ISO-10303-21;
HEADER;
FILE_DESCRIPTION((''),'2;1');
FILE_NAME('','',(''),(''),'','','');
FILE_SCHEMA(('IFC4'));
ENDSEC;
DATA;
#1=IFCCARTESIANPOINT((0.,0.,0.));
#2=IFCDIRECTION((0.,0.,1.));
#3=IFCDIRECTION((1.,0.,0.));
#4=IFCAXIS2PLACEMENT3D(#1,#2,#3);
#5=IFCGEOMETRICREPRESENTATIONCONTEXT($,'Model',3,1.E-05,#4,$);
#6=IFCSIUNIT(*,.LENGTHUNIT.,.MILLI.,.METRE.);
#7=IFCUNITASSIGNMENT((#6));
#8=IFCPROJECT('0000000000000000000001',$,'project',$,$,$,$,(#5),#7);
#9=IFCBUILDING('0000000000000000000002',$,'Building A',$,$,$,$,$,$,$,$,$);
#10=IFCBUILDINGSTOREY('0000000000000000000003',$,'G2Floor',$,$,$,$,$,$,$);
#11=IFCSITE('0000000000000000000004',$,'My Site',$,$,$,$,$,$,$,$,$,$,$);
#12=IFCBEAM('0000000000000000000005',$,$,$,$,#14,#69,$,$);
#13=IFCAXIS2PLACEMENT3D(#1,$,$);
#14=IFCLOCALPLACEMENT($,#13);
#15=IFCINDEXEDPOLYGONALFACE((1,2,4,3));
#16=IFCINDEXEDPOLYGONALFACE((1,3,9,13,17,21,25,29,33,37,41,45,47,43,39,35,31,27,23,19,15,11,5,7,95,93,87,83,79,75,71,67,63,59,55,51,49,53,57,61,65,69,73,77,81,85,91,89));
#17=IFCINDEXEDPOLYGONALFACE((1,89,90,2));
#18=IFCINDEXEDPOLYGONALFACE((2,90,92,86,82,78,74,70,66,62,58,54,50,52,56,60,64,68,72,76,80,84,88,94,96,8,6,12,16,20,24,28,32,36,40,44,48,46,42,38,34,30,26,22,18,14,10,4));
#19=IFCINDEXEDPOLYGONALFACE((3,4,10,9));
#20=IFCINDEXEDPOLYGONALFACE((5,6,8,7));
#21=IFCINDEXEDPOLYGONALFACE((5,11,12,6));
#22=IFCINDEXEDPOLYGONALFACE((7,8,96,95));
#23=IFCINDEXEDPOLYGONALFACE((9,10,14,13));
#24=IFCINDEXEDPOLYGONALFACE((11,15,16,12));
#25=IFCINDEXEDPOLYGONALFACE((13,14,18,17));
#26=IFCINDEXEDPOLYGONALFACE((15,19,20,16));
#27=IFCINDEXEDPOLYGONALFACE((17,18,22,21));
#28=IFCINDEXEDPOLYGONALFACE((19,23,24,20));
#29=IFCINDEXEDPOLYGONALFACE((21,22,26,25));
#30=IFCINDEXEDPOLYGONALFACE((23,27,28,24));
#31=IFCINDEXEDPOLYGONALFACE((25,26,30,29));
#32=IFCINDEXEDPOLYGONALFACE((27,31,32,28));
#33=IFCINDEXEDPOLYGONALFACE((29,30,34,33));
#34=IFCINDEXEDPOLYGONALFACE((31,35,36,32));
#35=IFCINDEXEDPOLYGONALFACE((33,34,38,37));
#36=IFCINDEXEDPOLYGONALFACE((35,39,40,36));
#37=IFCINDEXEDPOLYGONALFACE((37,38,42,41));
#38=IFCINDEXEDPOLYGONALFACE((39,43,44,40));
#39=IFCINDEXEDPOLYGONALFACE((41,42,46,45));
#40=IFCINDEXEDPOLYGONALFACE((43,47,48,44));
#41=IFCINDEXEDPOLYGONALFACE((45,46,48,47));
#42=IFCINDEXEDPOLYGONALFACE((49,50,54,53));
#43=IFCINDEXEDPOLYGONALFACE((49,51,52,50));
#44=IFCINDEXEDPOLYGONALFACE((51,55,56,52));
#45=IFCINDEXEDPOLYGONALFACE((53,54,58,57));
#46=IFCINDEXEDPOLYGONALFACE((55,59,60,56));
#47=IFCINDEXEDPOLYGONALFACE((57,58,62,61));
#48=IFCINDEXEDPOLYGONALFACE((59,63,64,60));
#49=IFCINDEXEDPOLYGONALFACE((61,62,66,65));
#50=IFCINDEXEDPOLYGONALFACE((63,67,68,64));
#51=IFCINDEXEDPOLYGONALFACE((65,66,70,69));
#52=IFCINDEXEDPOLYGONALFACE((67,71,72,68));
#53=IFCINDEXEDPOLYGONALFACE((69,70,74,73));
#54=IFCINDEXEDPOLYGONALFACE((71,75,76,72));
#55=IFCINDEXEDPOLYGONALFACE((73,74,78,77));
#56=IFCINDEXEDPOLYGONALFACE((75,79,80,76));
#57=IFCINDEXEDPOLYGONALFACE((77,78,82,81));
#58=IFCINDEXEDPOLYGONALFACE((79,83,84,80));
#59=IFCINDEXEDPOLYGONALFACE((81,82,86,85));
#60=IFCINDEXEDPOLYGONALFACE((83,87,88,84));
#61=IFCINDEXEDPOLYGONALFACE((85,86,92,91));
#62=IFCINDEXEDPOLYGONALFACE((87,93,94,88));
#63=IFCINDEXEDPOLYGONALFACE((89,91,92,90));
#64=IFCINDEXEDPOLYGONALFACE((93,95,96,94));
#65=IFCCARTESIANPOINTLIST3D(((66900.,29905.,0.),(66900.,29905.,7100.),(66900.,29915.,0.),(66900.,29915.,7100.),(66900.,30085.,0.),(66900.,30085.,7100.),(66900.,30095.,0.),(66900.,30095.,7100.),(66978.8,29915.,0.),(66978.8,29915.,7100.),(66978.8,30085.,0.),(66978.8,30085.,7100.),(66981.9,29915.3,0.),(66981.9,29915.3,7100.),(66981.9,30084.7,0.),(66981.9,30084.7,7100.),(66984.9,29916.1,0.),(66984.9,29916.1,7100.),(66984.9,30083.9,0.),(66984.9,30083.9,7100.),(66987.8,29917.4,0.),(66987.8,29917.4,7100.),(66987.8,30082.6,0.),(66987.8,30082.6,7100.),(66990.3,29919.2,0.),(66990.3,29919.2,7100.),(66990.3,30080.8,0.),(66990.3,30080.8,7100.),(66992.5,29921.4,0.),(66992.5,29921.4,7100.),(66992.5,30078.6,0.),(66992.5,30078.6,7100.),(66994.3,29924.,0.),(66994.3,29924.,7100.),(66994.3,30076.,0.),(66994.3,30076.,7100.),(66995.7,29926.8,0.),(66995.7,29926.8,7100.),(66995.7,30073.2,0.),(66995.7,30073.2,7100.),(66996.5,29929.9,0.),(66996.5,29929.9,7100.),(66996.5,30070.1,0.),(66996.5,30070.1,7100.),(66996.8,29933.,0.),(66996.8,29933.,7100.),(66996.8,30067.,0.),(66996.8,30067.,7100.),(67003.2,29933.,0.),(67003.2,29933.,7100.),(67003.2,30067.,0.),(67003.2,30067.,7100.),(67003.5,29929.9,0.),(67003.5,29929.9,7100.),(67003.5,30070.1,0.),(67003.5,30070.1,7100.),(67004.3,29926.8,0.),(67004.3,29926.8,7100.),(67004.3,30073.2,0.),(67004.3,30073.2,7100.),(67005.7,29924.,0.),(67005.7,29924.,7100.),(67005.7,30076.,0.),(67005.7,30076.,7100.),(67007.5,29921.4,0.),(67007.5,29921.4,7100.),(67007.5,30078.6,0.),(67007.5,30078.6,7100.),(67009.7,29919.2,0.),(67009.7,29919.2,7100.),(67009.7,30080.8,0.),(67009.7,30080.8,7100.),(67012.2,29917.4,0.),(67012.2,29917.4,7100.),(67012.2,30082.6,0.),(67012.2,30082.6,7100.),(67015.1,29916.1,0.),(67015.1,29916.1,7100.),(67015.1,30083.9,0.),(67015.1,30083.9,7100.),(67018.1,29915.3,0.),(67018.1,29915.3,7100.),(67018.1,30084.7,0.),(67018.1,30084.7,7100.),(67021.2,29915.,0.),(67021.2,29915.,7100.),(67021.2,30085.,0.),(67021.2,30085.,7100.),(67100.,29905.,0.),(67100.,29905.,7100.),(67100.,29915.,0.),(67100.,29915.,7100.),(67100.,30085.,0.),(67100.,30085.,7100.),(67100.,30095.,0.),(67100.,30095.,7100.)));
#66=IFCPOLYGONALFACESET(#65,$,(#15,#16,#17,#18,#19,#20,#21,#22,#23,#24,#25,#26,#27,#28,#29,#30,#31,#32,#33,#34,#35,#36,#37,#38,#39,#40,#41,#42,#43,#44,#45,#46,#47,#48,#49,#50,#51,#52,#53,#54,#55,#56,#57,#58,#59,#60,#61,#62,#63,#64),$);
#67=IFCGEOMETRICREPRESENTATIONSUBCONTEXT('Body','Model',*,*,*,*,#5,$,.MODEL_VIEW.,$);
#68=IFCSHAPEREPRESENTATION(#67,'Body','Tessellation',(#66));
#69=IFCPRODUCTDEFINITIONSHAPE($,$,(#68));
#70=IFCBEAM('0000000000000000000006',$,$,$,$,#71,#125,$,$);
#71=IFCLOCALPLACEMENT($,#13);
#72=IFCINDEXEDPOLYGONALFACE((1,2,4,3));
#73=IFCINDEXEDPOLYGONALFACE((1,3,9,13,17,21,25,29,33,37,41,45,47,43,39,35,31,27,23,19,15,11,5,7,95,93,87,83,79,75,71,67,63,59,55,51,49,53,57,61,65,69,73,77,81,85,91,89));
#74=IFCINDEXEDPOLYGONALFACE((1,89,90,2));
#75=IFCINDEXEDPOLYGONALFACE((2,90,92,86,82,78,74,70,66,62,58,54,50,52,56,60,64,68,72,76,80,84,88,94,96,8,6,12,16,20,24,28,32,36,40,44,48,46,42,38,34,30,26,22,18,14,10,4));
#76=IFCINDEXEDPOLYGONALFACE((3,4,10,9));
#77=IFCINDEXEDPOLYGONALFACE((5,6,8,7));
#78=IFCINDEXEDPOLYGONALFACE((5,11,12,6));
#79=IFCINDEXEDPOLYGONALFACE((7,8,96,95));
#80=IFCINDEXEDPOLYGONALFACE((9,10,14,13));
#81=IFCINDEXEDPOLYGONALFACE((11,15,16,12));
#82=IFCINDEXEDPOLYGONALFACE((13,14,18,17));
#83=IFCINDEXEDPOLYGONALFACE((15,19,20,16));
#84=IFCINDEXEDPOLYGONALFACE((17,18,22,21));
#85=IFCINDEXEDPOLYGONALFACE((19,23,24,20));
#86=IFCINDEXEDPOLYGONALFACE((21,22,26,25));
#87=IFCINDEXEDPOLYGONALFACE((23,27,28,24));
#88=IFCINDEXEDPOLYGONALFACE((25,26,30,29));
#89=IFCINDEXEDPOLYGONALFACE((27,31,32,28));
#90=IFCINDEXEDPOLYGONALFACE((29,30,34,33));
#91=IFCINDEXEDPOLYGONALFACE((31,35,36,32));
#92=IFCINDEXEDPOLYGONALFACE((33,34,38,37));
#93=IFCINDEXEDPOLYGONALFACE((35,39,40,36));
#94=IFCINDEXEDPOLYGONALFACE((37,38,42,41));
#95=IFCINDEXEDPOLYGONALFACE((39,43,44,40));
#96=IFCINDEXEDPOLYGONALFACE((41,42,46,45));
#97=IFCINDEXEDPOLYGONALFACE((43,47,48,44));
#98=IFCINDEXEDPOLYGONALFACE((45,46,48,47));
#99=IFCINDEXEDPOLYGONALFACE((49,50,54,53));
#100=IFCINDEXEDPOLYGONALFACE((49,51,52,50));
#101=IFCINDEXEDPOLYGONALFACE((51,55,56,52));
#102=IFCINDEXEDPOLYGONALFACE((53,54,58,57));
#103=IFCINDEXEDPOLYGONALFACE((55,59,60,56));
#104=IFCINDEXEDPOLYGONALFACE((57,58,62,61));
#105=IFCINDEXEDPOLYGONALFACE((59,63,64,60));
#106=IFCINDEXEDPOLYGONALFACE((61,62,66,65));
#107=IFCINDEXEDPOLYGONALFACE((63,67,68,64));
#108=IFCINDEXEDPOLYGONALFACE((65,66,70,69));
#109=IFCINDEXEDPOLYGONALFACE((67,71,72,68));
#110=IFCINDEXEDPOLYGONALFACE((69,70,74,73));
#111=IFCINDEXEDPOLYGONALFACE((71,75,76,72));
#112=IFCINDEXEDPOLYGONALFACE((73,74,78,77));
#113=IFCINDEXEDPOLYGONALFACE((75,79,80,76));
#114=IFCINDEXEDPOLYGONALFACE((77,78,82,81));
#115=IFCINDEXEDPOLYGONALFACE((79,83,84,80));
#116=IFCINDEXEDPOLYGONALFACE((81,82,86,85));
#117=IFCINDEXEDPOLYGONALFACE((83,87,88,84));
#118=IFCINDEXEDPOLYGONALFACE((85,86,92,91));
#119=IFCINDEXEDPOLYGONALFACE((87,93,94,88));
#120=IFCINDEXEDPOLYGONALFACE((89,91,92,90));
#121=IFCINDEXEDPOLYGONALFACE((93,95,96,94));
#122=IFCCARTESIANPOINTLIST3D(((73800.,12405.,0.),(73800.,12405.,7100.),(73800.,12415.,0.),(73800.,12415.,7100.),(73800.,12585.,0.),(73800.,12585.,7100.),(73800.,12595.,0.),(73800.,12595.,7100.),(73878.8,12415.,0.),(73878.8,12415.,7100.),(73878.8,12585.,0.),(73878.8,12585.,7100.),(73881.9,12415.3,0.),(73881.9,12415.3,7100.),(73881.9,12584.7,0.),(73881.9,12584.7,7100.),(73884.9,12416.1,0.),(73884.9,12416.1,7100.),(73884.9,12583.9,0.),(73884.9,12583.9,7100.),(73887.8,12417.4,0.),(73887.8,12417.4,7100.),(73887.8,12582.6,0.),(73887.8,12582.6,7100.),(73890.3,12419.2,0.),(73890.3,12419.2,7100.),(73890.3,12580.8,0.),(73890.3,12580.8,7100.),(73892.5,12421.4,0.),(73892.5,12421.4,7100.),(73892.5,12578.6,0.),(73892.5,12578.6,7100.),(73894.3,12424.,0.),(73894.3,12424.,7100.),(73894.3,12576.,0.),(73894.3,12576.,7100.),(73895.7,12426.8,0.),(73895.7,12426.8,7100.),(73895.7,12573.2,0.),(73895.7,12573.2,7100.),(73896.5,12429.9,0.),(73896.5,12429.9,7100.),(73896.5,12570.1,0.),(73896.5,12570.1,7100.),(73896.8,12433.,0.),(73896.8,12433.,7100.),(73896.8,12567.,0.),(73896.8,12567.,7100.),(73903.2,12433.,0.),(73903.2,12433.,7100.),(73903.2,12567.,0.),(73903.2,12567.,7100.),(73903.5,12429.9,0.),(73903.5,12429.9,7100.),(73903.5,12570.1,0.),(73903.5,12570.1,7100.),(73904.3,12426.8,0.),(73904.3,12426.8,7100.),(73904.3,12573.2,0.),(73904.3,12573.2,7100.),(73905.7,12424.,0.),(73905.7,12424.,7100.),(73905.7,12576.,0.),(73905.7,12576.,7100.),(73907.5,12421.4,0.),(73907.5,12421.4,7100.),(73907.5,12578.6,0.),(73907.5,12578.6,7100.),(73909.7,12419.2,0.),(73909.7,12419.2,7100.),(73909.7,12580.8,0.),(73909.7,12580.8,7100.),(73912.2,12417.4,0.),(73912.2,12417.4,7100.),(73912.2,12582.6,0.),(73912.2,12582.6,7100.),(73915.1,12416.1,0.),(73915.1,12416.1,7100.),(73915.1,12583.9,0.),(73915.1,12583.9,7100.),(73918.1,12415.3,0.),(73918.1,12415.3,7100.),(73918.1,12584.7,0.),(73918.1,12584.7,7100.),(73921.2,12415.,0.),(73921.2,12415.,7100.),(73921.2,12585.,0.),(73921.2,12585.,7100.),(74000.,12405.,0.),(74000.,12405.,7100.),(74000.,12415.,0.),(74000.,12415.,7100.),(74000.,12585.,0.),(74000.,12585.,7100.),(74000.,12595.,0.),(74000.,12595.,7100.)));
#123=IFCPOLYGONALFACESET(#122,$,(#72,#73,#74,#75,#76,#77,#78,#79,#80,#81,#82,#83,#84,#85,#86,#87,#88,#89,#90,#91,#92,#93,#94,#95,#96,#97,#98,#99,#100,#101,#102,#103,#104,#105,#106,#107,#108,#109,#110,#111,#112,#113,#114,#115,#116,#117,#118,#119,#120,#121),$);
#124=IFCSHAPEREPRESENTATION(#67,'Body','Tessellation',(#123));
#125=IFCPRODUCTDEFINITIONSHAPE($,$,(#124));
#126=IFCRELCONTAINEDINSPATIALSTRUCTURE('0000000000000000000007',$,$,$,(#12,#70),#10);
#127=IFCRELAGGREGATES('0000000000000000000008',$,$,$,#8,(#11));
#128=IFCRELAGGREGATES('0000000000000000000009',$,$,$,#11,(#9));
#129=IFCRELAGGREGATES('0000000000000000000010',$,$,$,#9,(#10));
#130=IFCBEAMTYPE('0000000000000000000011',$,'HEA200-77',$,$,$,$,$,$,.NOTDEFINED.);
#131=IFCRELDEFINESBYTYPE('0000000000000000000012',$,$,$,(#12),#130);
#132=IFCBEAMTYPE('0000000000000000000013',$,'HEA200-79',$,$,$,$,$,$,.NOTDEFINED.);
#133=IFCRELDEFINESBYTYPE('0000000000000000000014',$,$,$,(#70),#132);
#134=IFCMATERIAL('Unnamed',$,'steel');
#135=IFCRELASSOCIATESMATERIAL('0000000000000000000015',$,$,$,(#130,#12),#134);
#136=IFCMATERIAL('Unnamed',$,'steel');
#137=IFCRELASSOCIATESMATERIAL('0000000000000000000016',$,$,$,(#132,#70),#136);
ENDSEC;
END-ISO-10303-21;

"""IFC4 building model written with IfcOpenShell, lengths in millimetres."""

from ifc_helpers import new_model, si_unit, frame, origin_with_axes, place, context, subcontext, project, spatial, polyline, outline, extrude, material, material_profile, profile_set, profile_usage, type_object, element, save


model = new_model("IFC4")

# Units and contexts
model_context = context("Model", 3, precision=1e-05, world=origin_with_axes())
body_context = subcontext(model_context, "Body", "Model", "MODEL_VIEW")
ifc_project = project(units=[si_unit("LENGTHUNIT", "METRE", prefix="MILLI")], contexts=[model_context])

# Site, building, storey
site = spatial("IfcSite", under=ifc_project, Name="My Site")
building = spatial("IfcBuilding", under=site, Name="Building A")
storey = spatial("IfcBuildingStorey", under=building, Name="G2Floor")

# Beams
ifc_material_1 = material(Name="Unnamed", Category="steel")
ifc_material_profile_1 = material_profile(ifc_material_1, outline(polyline([(100.0, -95.0), (100.0, -85.0), (100.0, -85.0), (21.2, -85.0), (21.2, -85.0), (18.1, -84.7), (18.1, -84.7), (15.1, -83.9), (15.1, -83.9), (12.2, -82.6), (12.2, -82.6), (9.7, -80.8), (9.7, -80.8), (7.5, -78.6), (7.5, -78.6), (5.7, -76.0), (5.7, -76.0), (4.3, -73.2), (4.3, -73.2), (3.5, -70.1), (3.5, -70.1), (3.2, -67.0), (3.2, -67.0), (3.2, 67.0), (3.2, 67.0), (3.5, 70.1), (3.5, 70.1), (4.3, 73.2), (4.3, 73.2), (5.7, 76.0), (5.7, 76.0), (7.5, 78.6), (7.5, 78.6), (9.7, 80.8), (9.7, 80.8), (12.2, 82.6), (12.2, 82.6), (15.1, 83.9), (15.1, 83.9), (18.1, 84.7), (18.1, 84.7), (21.2, 85.0), (21.2, 85.0), (100.0, 85.0), (100.0, 85.0), (100.0, 95.0), (100.0, 95.0), (-100.0, 95.0), (-100.0, 95.0), (-100.0, 85.0), (-100.0, 85.0), (-21.2, 85.0), (-21.2, 85.0), (-18.1, 84.7), (-18.1, 84.7), (-15.1, 83.9), (-15.1, 83.9), (-12.2, 82.6), (-12.2, 82.6), (-9.7, 80.8), (-9.7, 80.8), (-7.5, 78.6), (-7.5, 78.6), (-5.7, 76.0), (-5.7, 76.0), (-4.3, 73.2), (-4.3, 73.2), (-3.5, 70.1), (-3.5, 70.1), (-3.2, 67.0), (-3.2, 67.0), (-3.2, -67.0), (-3.2, -67.0), (-3.5, -70.1), (-3.5, -70.1), (-4.3, -73.2), (-4.3, -73.2), (-5.7, -76.0), (-5.7, -76.0), (-7.5, -78.6), (-7.5, -78.6), (-9.7, -80.8), (-9.7, -80.8), (-12.2, -82.6), (-12.2, -82.6), (-15.1, -83.9), (-15.1, -83.9), (-18.1, -84.7), (-18.1, -84.7), (-21.2, -85.0), (-21.2, -85.0), (-100.0, -85.0), (-100.0, -85.0), (-100.0, -95.0), (-100.0, -95.0), (100.0, -95.0)])))
ifc_profile_set_1 = profile_set([ifc_material_profile_1], Name="HEA200-77")
ifc_profile_usage_1 = profile_usage(ifc_profile_set_1)
beam_type_1 = type_object("IfcBeamType", Name="HEA200-77", PredefinedType="NOTDEFINED", material=ifc_profile_set_1)
beam_1_placement = place(None, frame((67000.0, 30000.0, 0.0), z_axis=(0.0, 0.0, 1.0), x_axis=(1.0, 0.0, 0.0)))
element("IfcBeam", 1, at=beam_1_placement, inside=storey, type_object=beam_type_1, material=ifc_profile_usage_1, context=body_context, shape_type="SweptSolid", body=[
    extrude(outline(polyline([(100.0, -95.0), (100.0, -85.0), (100.0, -85.0), (21.2, -85.0), (21.2, -85.0), (18.1, -84.7), (18.1, -84.7), (15.1, -83.9), (15.1, -83.9), (12.2, -82.6), (12.2, -82.6), (9.7, -80.8), (9.7, -80.8), (7.5, -78.6), (7.5, -78.6), (5.7, -76.0), (5.7, -76.0), (4.3, -73.2), (4.3, -73.2), (3.5, -70.1), (3.5, -70.1), (3.2, -67.0), (3.2, -67.0), (3.2, 67.0), (3.2, 67.0), (3.5, 70.1), (3.5, 70.1), (4.3, 73.2), (4.3, 73.2), (5.7, 76.0), (5.7, 76.0), (7.5, 78.6), (7.5, 78.6), (9.7, 80.8), (9.7, 80.8), (12.2, 82.6), (12.2, 82.6), (15.1, 83.9), (15.1, 83.9), (18.1, 84.7), (18.1, 84.7), (21.2, 85.0), (21.2, 85.0), (100.0, 85.0), (100.0, 85.0), (100.0, 95.0), (100.0, 95.0), (-100.0, 95.0), (-100.0, 95.0), (-100.0, 85.0), (-100.0, 85.0), (-21.2, 85.0), (-21.2, 85.0), (-18.1, 84.7), (-18.1, 84.7), (-15.1, 83.9), (-15.1, 83.9), (-12.2, 82.6), (-12.2, 82.6), (-9.7, 80.8), (-9.7, 80.8), (-7.5, 78.6), (-7.5, 78.6), (-5.7, 76.0), (-5.7, 76.0), (-4.3, 73.2), (-4.3, 73.2), (-3.5, 70.1), (-3.5, 70.1), (-3.2, 67.0), (-3.2, 67.0), (-3.2, -67.0), (-3.2, -67.0), (-3.5, -70.1), (-3.5, -70.1), (-4.3, -73.2), (-4.3, -73.2), (-5.7, -76.0), (-5.7, -76.0), (-7.5, -78.6), (-7.5, -78.6), (-9.7, -80.8), (-9.7, -80.8), (-12.2, -82.6), (-12.2, -82.6), (-15.1, -83.9), (-15.1, -83.9), (-18.1, -84.7), (-18.1, -84.7), (-21.2, -85.0), (-21.2, -85.0), (-100.0, -85.0), (-100.0, -85.0), (-100.0, -95.0), (-100.0, -95.0), (100.0, -95.0)])), origin_with_axes(), (0.0, 0.0, 1.0), 7100.0),
])
ifc_material_2 = material(Name="Unnamed", Category="steel")
ifc_material_profile_2 = material_profile(ifc_material_2, outline(polyline([(100.0, -95.0), (100.0, -85.0), (100.0, -85.0), (21.2, -85.0), (21.2, -85.0), (18.1, -84.7), (18.1, -84.7), (15.1, -83.9), (15.1, -83.9), (12.2, -82.6), (12.2, -82.6), (9.7, -80.8), (9.7, -80.8), (7.5, -78.6), (7.5, -78.6), (5.7, -76.0), (5.7, -76.0), (4.3, -73.2), (4.3, -73.2), (3.5, -70.1), (3.5, -70.1), (3.2, -67.0), (3.2, -67.0), (3.2, 67.0), (3.2, 67.0), (3.5, 70.1), (3.5, 70.1), (4.3, 73.2), (4.3, 73.2), (5.7, 76.0), (5.7, 76.0), (7.5, 78.6), (7.5, 78.6), (9.7, 80.8), (9.7, 80.8), (12.2, 82.6), (12.2, 82.6), (15.1, 83.9), (15.1, 83.9), (18.1, 84.7), (18.1, 84.7), (21.2, 85.0), (21.2, 85.0), (100.0, 85.0), (100.0, 85.0), (100.0, 95.0), (100.0, 95.0), (-100.0, 95.0), (-100.0, 95.0), (-100.0, 85.0), (-100.0, 85.0), (-21.2, 85.0), (-21.2, 85.0), (-18.1, 84.7), (-18.1, 84.7), (-15.1, 83.9), (-15.1, 83.9), (-12.2, 82.6), (-12.2, 82.6), (-9.7, 80.8), (-9.7, 80.8), (-7.5, 78.6), (-7.5, 78.6), (-5.7, 76.0), (-5.7, 76.0), (-4.3, 73.2), (-4.3, 73.2), (-3.5, 70.1), (-3.5, 70.1), (-3.2, 67.0), (-3.2, 67.0), (-3.2, -67.0), (-3.2, -67.0), (-3.5, -70.1), (-3.5, -70.1), (-4.3, -73.2), (-4.3, -73.2), (-5.7, -76.0), (-5.7, -76.0), (-7.5, -78.6), (-7.5, -78.6), (-9.7, -80.8), (-9.7, -80.8), (-12.2, -82.6), (-12.2, -82.6), (-15.1, -83.9), (-15.1, -83.9), (-18.1, -84.7), (-18.1, -84.7), (-21.2, -85.0), (-21.2, -85.0), (-100.0, -85.0), (-100.0, -85.0), (-100.0, -95.0), (-100.0, -95.0), (100.0, -95.0)])))
ifc_profile_set_2 = profile_set([ifc_material_profile_2], Name="HEA200-79")
ifc_profile_usage_2 = profile_usage(ifc_profile_set_2)
beam_type_2 = type_object("IfcBeamType", Name="HEA200-79", PredefinedType="NOTDEFINED", material=ifc_profile_set_2)
beam_2_placement = place(None, frame((73900.0, 12500.0, 0.0), z_axis=(0.0, 0.0, 1.0), x_axis=(1.0, 0.0, 0.0)))
element("IfcBeam", 2, at=beam_2_placement, inside=storey, type_object=beam_type_2, material=ifc_profile_usage_2, context=body_context, shape_type="SweptSolid", body=[
    extrude(outline(polyline([(100.0, -95.0), (100.0, -85.0), (100.0, -85.0), (21.2, -85.0), (21.2, -85.0), (18.1, -84.7), (18.1, -84.7), (15.1, -83.9), (15.1, -83.9), (12.2, -82.6), (12.2, -82.6), (9.7, -80.8), (9.7, -80.8), (7.5, -78.6), (7.5, -78.6), (5.7, -76.0), (5.7, -76.0), (4.3, -73.2), (4.3, -73.2), (3.5, -70.1), (3.5, -70.1), (3.2, -67.0), (3.2, -67.0), (3.2, 67.0), (3.2, 67.0), (3.5, 70.1), (3.5, 70.1), (4.3, 73.2), (4.3, 73.2), (5.7, 76.0), (5.7, 76.0), (7.5, 78.6), (7.5, 78.6), (9.7, 80.8), (9.7, 80.8), (12.2, 82.6), (12.2, 82.6), (15.1, 83.9), (15.1, 83.9), (18.1, 84.7), (18.1, 84.7), (21.2, 85.0), (21.2, 85.0), (100.0, 85.0), (100.0, 85.0), (100.0, 95.0), (100.0, 95.0), (-100.0, 95.0), (-100.0, 95.0), (-100.0, 85.0), (-100.0, 85.0), (-21.2, 85.0), (-21.2, 85.0), (-18.1, 84.7), (-18.1, 84.7), (-15.1, 83.9), (-15.1, 83.9), (-12.2, 82.6), (-12.2, 82.6), (-9.7, 80.8), (-9.7, 80.8), (-7.5, 78.6), (-7.5, 78.6), (-5.7, 76.0), (-5.7, 76.0), (-4.3, 73.2), (-4.3, 73.2), (-3.5, 70.1), (-3.5, 70.1), (-3.2, 67.0), (-3.2, 67.0), (-3.2, -67.0), (-3.2, -67.0), (-3.5, -70.1), (-3.5, -70.1), (-4.3, -73.2), (-4.3, -73.2), (-5.7, -76.0), (-5.7, -76.0), (-7.5, -78.6), (-7.5, -78.6), (-9.7, -80.8), (-9.7, -80.8), (-12.2, -82.6), (-12.2, -82.6), (-15.1, -83.9), (-15.1, -83.9), (-18.1, -84.7), (-18.1, -84.7), (-21.2, -85.0), (-21.2, -85.0), (-100.0, -85.0), (-100.0, -85.0), (-100.0, -95.0), (-100.0, -95.0), (100.0, -95.0)])), origin_with_axes(), (0.0, 0.0, 1.0), 7100.0),
])

save(model, "model.ifc")
